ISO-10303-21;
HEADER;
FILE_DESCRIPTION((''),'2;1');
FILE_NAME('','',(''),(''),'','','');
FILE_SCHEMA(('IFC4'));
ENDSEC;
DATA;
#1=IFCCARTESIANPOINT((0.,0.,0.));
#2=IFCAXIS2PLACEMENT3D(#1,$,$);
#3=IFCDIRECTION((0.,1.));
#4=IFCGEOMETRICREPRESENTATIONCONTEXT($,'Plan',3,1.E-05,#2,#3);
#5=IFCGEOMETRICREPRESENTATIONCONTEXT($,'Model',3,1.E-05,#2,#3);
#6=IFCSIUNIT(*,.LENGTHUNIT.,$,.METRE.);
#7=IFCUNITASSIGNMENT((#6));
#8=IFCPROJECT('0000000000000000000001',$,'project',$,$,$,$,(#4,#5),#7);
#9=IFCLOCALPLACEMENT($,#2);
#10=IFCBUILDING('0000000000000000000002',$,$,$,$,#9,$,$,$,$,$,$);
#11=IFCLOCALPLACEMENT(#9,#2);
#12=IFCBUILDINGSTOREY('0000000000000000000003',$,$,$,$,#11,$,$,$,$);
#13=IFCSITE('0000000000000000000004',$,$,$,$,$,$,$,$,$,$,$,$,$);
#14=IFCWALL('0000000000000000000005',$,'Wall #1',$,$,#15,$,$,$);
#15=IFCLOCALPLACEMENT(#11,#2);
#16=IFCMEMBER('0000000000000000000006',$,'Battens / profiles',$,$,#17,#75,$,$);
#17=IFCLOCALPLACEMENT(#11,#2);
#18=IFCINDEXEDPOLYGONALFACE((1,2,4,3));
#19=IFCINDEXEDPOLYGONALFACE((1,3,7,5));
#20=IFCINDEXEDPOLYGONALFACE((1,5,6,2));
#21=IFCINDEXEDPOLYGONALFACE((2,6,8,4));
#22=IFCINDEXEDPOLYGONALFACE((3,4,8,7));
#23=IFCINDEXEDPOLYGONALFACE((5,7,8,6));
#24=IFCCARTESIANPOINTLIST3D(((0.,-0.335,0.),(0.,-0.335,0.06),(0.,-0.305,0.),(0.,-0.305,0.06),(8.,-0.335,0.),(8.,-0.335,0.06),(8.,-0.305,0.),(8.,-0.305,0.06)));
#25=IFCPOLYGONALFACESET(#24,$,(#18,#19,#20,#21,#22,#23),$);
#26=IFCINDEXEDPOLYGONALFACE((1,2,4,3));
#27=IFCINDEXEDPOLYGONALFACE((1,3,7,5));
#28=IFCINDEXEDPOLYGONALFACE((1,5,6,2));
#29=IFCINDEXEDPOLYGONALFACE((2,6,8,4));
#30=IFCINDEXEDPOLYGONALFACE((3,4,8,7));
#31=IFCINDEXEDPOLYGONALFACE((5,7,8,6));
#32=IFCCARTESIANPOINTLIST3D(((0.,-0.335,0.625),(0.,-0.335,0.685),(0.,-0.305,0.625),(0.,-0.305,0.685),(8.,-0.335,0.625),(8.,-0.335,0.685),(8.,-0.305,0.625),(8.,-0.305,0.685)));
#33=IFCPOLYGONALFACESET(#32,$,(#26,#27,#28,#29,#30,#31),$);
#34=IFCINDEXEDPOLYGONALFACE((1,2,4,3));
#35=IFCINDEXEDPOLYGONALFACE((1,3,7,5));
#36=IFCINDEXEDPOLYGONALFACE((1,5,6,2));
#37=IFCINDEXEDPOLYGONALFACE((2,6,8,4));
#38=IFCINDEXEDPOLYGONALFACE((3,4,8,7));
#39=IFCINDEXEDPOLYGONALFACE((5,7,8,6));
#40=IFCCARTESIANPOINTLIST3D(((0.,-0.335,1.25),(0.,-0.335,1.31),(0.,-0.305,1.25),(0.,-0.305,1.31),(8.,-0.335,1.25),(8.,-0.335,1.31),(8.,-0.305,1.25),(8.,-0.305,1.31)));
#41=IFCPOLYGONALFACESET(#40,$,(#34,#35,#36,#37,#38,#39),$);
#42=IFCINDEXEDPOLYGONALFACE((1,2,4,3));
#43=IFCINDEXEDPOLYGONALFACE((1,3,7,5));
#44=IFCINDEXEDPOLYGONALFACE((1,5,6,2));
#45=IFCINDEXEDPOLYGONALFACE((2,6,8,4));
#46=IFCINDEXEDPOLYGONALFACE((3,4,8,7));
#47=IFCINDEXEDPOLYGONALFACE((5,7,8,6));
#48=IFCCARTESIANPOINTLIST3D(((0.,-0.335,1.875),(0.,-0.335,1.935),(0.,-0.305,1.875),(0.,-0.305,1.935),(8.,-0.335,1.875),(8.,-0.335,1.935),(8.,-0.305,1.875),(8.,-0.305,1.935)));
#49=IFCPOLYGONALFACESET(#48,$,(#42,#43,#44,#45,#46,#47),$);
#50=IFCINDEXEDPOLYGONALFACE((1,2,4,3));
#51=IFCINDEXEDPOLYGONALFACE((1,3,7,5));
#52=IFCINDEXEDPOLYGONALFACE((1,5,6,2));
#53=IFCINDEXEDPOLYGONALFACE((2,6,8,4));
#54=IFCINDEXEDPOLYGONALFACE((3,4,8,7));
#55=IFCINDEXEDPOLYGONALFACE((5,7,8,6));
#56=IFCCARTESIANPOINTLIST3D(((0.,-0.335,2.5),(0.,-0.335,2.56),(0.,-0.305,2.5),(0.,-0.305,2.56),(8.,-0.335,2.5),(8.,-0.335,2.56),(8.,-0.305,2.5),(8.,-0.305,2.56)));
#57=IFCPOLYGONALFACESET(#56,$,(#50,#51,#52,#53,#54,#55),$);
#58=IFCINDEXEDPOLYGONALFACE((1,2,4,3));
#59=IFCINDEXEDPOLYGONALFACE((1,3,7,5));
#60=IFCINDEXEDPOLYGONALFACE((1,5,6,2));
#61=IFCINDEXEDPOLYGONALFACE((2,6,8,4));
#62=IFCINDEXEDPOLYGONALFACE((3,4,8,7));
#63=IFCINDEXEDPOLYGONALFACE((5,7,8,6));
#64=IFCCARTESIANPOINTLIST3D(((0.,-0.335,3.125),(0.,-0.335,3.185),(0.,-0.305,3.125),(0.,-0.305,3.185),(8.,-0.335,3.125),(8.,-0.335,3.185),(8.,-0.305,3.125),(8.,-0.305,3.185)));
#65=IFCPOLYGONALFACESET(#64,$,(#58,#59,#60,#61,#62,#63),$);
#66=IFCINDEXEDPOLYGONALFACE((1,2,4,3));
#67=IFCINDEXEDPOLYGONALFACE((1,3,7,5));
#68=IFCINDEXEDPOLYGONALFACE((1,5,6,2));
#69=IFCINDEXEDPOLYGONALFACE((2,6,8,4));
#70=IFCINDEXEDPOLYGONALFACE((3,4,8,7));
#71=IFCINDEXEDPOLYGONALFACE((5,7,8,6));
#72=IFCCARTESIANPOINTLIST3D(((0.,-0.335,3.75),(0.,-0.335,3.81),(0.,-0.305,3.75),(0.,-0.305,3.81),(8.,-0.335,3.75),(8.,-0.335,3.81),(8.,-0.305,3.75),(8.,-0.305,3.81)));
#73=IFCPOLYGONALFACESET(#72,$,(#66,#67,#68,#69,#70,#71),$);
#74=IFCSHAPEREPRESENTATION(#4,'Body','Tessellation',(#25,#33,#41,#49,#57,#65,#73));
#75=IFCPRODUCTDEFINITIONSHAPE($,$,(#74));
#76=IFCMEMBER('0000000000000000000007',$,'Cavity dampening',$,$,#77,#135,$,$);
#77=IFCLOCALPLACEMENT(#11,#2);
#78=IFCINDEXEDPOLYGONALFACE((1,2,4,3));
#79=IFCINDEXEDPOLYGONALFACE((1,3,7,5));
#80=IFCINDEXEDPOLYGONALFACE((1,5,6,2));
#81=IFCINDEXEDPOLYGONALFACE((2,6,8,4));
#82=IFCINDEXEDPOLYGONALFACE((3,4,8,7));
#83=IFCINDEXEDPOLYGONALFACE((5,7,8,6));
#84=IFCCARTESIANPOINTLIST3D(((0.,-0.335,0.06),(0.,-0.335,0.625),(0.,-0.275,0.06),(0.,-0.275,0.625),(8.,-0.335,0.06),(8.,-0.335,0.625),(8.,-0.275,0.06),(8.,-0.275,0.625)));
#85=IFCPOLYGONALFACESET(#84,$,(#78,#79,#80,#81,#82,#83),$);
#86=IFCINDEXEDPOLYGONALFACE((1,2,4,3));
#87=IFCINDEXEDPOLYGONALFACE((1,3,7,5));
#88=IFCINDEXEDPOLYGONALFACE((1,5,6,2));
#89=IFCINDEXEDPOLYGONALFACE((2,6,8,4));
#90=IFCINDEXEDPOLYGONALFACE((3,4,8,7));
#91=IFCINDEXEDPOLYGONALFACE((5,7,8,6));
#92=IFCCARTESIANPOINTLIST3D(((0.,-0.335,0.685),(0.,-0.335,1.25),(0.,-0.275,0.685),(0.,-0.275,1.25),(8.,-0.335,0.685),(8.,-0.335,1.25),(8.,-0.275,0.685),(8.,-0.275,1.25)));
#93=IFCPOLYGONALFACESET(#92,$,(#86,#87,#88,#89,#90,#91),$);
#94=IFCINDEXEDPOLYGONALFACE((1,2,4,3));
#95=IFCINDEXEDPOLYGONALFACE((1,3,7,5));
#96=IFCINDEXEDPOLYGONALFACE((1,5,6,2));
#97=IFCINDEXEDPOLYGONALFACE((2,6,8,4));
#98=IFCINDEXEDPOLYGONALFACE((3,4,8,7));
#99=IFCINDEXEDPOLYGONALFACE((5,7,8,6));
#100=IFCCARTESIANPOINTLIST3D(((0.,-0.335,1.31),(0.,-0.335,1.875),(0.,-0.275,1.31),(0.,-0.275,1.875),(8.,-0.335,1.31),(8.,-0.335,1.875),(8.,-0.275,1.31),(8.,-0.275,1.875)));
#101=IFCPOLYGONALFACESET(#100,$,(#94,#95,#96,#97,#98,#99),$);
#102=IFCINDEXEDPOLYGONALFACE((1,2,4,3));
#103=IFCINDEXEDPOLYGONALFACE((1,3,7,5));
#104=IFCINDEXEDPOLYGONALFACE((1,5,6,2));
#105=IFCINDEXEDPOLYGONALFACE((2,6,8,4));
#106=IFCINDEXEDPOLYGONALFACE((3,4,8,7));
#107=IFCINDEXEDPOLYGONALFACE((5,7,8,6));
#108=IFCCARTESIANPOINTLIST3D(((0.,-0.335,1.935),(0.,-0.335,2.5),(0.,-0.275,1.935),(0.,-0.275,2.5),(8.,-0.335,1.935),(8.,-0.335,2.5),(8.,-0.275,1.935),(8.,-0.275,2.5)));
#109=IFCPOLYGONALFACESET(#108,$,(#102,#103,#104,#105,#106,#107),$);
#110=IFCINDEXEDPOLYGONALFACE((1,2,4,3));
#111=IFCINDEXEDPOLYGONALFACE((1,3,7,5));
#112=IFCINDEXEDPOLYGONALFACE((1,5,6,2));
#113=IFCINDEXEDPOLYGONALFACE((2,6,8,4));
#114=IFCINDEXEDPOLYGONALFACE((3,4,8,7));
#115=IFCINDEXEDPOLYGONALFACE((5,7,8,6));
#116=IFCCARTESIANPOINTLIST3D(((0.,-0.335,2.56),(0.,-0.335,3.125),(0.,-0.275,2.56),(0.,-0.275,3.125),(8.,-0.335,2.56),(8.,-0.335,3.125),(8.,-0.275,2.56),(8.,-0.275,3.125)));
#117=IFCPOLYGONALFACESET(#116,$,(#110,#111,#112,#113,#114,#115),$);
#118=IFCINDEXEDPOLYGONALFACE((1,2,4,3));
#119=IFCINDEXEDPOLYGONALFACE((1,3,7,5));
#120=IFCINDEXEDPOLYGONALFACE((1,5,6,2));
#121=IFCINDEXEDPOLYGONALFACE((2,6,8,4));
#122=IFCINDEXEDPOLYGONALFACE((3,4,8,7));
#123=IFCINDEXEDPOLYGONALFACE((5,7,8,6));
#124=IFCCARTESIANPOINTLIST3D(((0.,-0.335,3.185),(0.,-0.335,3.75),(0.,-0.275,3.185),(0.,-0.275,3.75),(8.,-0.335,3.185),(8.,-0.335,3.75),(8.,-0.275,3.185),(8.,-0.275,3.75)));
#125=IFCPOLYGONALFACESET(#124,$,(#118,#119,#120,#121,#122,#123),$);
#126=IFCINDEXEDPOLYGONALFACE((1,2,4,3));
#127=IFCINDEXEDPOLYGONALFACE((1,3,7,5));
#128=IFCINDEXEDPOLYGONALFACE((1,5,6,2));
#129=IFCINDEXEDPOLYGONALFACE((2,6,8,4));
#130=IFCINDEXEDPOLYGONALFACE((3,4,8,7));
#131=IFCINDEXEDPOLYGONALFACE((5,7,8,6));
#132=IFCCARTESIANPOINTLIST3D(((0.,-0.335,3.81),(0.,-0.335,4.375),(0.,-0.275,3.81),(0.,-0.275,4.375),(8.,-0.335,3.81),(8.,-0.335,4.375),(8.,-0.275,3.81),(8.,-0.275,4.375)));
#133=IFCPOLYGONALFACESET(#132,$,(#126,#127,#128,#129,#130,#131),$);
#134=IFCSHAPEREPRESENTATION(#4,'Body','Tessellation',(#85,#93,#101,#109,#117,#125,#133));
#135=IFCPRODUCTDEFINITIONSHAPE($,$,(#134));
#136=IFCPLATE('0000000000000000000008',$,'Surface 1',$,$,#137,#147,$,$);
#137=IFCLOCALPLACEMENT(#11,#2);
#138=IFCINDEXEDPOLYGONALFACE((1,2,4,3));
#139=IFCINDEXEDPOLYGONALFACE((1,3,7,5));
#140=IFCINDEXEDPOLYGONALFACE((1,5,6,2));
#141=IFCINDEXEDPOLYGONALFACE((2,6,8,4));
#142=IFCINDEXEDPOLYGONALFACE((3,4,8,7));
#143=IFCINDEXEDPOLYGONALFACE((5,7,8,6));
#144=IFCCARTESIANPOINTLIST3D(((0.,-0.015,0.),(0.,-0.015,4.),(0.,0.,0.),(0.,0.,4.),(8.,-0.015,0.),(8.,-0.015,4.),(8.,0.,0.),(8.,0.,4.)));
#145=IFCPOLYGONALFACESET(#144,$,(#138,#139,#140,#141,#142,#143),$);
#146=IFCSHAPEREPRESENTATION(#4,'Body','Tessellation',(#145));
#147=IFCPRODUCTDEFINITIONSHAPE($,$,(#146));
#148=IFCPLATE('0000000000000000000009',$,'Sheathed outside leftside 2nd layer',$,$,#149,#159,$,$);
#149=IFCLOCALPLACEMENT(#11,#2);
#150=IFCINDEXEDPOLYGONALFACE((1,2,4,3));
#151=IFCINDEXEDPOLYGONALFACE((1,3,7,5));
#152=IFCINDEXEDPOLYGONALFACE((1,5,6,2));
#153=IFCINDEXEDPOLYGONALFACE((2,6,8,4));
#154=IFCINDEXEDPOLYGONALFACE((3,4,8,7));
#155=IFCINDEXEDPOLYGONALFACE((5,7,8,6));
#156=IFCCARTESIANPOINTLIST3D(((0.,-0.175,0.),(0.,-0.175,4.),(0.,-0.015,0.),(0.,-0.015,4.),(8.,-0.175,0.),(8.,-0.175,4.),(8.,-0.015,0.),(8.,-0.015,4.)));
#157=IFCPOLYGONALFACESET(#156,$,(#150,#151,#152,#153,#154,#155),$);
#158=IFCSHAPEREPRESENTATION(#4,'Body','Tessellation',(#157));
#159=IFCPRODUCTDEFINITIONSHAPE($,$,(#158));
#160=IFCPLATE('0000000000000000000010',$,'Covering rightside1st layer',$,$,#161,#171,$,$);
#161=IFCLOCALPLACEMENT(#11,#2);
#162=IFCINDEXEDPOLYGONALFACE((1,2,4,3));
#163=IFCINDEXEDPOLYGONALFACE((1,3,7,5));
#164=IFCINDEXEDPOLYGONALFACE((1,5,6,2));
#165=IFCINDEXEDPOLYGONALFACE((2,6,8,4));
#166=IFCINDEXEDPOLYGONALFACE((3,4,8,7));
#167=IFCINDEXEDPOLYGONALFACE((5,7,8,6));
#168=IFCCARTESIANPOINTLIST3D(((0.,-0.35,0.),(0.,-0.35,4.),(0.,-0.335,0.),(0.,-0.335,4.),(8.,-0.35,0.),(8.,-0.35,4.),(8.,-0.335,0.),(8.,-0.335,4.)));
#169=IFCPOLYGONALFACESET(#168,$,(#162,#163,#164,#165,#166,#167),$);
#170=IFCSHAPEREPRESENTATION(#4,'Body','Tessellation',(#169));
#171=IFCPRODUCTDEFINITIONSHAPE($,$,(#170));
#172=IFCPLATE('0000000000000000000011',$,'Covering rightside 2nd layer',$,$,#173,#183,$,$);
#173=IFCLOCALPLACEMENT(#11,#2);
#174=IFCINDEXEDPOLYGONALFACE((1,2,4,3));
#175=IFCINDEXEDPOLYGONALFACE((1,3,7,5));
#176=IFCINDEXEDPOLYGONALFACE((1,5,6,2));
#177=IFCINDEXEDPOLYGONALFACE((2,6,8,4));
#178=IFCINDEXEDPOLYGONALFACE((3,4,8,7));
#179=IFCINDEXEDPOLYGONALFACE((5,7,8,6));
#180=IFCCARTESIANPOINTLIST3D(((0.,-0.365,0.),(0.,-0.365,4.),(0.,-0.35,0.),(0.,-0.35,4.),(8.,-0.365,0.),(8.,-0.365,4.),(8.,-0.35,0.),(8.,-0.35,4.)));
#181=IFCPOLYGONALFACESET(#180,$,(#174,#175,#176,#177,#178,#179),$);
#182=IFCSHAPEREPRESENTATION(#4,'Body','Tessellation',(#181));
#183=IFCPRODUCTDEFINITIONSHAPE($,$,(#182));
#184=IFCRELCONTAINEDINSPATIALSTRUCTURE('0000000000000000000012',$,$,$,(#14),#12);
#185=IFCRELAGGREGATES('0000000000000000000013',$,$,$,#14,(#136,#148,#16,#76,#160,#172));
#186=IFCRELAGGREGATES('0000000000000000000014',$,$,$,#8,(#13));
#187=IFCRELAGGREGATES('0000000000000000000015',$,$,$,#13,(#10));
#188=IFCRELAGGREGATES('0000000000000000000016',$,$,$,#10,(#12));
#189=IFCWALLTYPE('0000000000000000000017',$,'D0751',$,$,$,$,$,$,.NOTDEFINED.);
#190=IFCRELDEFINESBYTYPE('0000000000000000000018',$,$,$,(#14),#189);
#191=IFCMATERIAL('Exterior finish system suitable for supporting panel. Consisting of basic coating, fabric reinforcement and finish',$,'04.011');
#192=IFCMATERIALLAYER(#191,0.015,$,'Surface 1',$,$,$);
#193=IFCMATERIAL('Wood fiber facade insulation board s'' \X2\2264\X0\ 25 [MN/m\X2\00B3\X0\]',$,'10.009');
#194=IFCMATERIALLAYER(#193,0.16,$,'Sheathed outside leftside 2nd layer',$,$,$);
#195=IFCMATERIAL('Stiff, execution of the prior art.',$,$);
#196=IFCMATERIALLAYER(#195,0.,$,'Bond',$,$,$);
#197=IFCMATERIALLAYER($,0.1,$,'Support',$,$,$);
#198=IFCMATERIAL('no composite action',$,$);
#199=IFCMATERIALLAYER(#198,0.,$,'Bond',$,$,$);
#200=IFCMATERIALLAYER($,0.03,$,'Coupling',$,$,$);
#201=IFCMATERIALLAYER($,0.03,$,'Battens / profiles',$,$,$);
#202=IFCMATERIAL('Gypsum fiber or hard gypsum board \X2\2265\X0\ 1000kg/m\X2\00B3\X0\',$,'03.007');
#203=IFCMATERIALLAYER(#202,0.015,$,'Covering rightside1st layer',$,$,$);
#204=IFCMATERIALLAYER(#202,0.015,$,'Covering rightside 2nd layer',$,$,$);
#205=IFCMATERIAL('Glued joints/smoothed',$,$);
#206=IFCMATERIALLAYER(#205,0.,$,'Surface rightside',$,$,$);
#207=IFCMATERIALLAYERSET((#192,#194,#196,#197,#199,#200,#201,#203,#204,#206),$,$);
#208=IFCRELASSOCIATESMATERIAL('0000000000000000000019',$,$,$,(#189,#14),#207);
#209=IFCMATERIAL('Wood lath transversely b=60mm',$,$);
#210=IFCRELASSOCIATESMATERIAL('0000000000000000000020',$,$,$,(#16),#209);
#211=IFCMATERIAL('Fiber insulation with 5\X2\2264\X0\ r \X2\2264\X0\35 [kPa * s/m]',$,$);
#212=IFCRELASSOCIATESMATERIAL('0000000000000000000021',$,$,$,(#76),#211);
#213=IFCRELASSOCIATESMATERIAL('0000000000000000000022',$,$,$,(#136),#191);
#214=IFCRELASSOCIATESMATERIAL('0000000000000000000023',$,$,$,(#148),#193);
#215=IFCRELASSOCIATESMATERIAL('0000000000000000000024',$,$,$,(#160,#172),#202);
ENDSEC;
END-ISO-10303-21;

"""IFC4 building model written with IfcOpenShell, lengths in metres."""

from ifc_helpers import new_model, si_unit, direction, frame, frame_2d, origin, origin_with_axes, place, context, project, spatial, rectangle, extrude, material, layer, layer_set, type_object, element, aggregate, save


model = new_model("IFC4")

# Units and contexts
plan_context = context("Plan", 3, precision=1e-05, world=origin(), true_north=direction((0.0, 1.0)))
model_context = context("Model", 3, precision=1e-05, world=origin(), true_north=direction((0.0, 1.0)))
ifc_project = project(units=[si_unit("LENGTHUNIT", "METRE")], contexts=[plan_context, model_context])

# Site, building, storey
site = spatial("IfcSite", under=ifc_project)
building_placement = place(None, origin())
building = spatial("IfcBuilding", under=site, at=building_placement)
storey_placement = place(building_placement, origin())
storey = spatial("IfcBuildingStorey", under=building, at=storey_placement)

# Wall, members, plates
ifc_material_1 = material(Name="Exterior finish system suitable for supporting panel. Consisting of basic coating, fabric reinforcement and finish", Category="04.011")
ifc_layer_1 = layer(ifc_material_1, 0.015, Name="Surface 1")
ifc_material_2 = material(Name="Wood fiber facade insulation board s' ≤ 25 [MN/m³]", Category="10.009")
ifc_layer_2 = layer(ifc_material_2, 0.16, Name="Sheathed outside leftside 2nd layer")
ifc_material_3 = material(Name="Stiff, execution of the prior art.")
ifc_layer_3 = layer(ifc_material_3, 0.0, Name="Bond")
ifc_layer_4 = layer(None, 0.1, Name="Support")
ifc_material_4 = material(Name="no composite action")
ifc_layer_5 = layer(ifc_material_4, 0.0, Name="Bond")
ifc_layer_6 = layer(None, 0.03, Name="Coupling")
ifc_layer_7 = layer(None, 0.03, Name="Battens / profiles")
ifc_material_5 = material(Name="Gypsum fiber or hard gypsum board ≥ 1000kg/m³", Category="03.007")
ifc_layer_8 = layer(ifc_material_5, 0.015, Name="Covering rightside1st layer")
ifc_layer_9 = layer(ifc_material_5, 0.015, Name="Covering rightside 2nd layer")
ifc_material_6 = material(Name="Glued joints/smoothed")
ifc_layer_10 = layer(ifc_material_6, 0.0, Name="Surface rightside")
ifc_layer_set = layer_set([ifc_layer_1, ifc_layer_2, ifc_layer_3, ifc_layer_4, ifc_layer_5, ifc_layer_6, ifc_layer_7, ifc_layer_8, ifc_layer_9, ifc_layer_10])
wall_type = type_object("IfcWallType", Name="D0751", PredefinedType="NOTDEFINED", material=ifc_layer_set)
wall_placement = place(None, frame((0.0, 0.0, 0.0), z_axis=(0.0, -1.0, 0.0), x_axis=(1.0, 0.0, 0.0)))
wall = element("IfcWall", 1, at=wall_placement, inside=storey, type_object=wall_type, material=ifc_layer_set, Name="Wall #1")
ifc_material_7 = material(Name="Wood lath transversely b=60mm")
member_1_placement = place(wall_placement, origin())
member_1 = element("IfcMember", 2, at=member_1_placement, material=ifc_material_7, Name="Battens / profiles", context=plan_context, shape_type="SweptSolid", body=[
    extrude(rectangle(XDim=0.06, YDim=0.03, at=frame_2d((0.03, 0.015), x_axis=(1.0, 0.0))), frame((0.0, 0.0, 0.305), z_axis=(1.0, 0.0, 0.0), x_axis=(0.0, 1.0, 0.0)), (0.0, 0.0, 1.0), 8.0),
    extrude(rectangle(XDim=0.06, YDim=0.03, at=frame_2d((0.03, 0.015), x_axis=(1.0, 0.0))), frame((0.0, 0.625, 0.305), z_axis=(1.0, 0.0, 0.0), x_axis=(0.0, 1.0, 0.0)), (0.0, 0.0, 1.0), 8.0),
    extrude(rectangle(XDim=0.06, YDim=0.03, at=frame_2d((0.03, 0.015), x_axis=(1.0, 0.0))), frame((0.0, 1.25, 0.305), z_axis=(1.0, 0.0, 0.0), x_axis=(0.0, 1.0, 0.0)), (0.0, 0.0, 1.0), 8.0),
    extrude(rectangle(XDim=0.06, YDim=0.03, at=frame_2d((0.03, 0.015), x_axis=(1.0, 0.0))), frame((0.0, 1.875, 0.305), z_axis=(1.0, 0.0, 0.0), x_axis=(0.0, 1.0, 0.0)), (0.0, 0.0, 1.0), 8.0),
    extrude(rectangle(XDim=0.06, YDim=0.03, at=frame_2d((0.03, 0.015), x_axis=(1.0, 0.0))), frame((0.0, 2.5, 0.305), z_axis=(1.0, 0.0, 0.0), x_axis=(0.0, 1.0, 0.0)), (0.0, 0.0, 1.0), 8.0),
    extrude(rectangle(XDim=0.06, YDim=0.03, at=frame_2d((0.03, 0.015), x_axis=(1.0, 0.0))), frame((0.0, 3.125, 0.305), z_axis=(1.0, 0.0, 0.0), x_axis=(0.0, 1.0, 0.0)), (0.0, 0.0, 1.0), 8.0),
    extrude(rectangle(XDim=0.06, YDim=0.03, at=frame_2d((0.03, 0.015), x_axis=(1.0, 0.0))), frame((0.0, 3.75, 0.305), z_axis=(1.0, 0.0, 0.0), x_axis=(0.0, 1.0, 0.0)), (0.0, 0.0, 1.0), 8.0),
])
ifc_material_8 = material(Name="Fiber insulation with 5≤ r ≤35 [kPa * s/m]")
member_2_placement = place(wall_placement, origin())
member_2 = element("IfcMember", 3, at=member_2_placement, material=ifc_material_8, Name="Cavity dampening", context=plan_context, shape_type="SweptSolid", body=[
    extrude(rectangle(XDim=0.565, YDim=0.06, at=frame_2d((0.2825, 0.03), x_axis=(1.0, 0.0))), frame((0.0, 0.06, 0.275), z_axis=(1.0, 0.0, 0.0), x_axis=(0.0, 1.0, 0.0)), (0.0, 0.0, 1.0), 8.0),
    extrude(rectangle(XDim=0.565, YDim=0.06, at=frame_2d((0.2825, 0.03), x_axis=(1.0, 0.0))), frame((0.0, 0.685, 0.275), z_axis=(1.0, 0.0, 0.0), x_axis=(0.0, 1.0, 0.0)), (0.0, 0.0, 1.0), 8.0),
    extrude(rectangle(XDim=0.565, YDim=0.06, at=frame_2d((0.2825, 0.03), x_axis=(1.0, 0.0))), frame((0.0, 1.31, 0.275), z_axis=(1.0, 0.0, 0.0), x_axis=(0.0, 1.0, 0.0)), (0.0, 0.0, 1.0), 8.0),
    extrude(rectangle(XDim=0.565, YDim=0.06, at=frame_2d((0.2825, 0.03), x_axis=(1.0, 0.0))), frame((0.0, 1.935, 0.275), z_axis=(1.0, 0.0, 0.0), x_axis=(0.0, 1.0, 0.0)), (0.0, 0.0, 1.0), 8.0),
    extrude(rectangle(XDim=0.565, YDim=0.06, at=frame_2d((0.2825, 0.03), x_axis=(1.0, 0.0))), frame((0.0, 2.56, 0.275), z_axis=(1.0, 0.0, 0.0), x_axis=(0.0, 1.0, 0.0)), (0.0, 0.0, 1.0), 8.0),
    extrude(rectangle(XDim=0.565, YDim=0.06, at=frame_2d((0.2825, 0.03), x_axis=(1.0, 0.0))), frame((0.0, 3.185, 0.275), z_axis=(1.0, 0.0, 0.0), x_axis=(0.0, 1.0, 0.0)), (0.0, 0.0, 1.0), 8.0),
    extrude(rectangle(XDim=0.565, YDim=0.06, at=frame_2d((0.2825, 0.03), x_axis=(1.0, 0.0))), frame((0.0, 3.81, 0.275), z_axis=(1.0, 0.0, 0.0), x_axis=(0.0, 1.0, 0.0)), (0.0, 0.0, 1.0), 8.0),
])
plate_1_placement = place(wall_placement, origin())
plate_1 = element("IfcPlate", 4, at=plate_1_placement, material=ifc_material_1, Name="Surface 1", context=plan_context, shape_type="SweptSolid", body=[
    extrude(rectangle(XDim=8.0, YDim=4.0, at=frame_2d((4.0, 2.0), x_axis=(1.0, 0.0))), origin_with_axes(), (0.0, 0.0, 1.0), 0.015),
])
plate_2_placement = place(wall_placement, origin())
plate_2 = element("IfcPlate", 5, at=plate_2_placement, material=ifc_material_2, Name="Sheathed outside leftside 2nd layer", context=plan_context, shape_type="SweptSolid", body=[
    extrude(rectangle(XDim=8.0, YDim=4.0, at=frame_2d((4.0, 2.0), x_axis=(1.0, 0.0))), frame((0.0, 0.0, 0.015), z_axis=(0.0, 0.0, 1.0), x_axis=(1.0, 0.0, 0.0)), (0.0, 0.0, 1.0), 0.16),
])
plate_3_placement = place(wall_placement, origin())
plate_3 = element("IfcPlate", 6, at=plate_3_placement, material=ifc_material_5, Name="Covering rightside1st layer", context=plan_context, shape_type="SweptSolid", body=[
    extrude(rectangle(XDim=8.0, YDim=4.0, at=frame_2d((4.0, 2.0), x_axis=(1.0, 0.0))), frame((0.0, 0.0, 0.335), z_axis=(0.0, 0.0, 1.0), x_axis=(1.0, 0.0, 0.0)), (0.0, 0.0, 1.0), 0.015),
])
plate_4_placement = place(wall_placement, origin())
plate_4 = element("IfcPlate", 7, at=plate_4_placement, material=ifc_material_5, Name="Covering rightside 2nd layer", context=plan_context, shape_type="SweptSolid", body=[
    extrude(rectangle(XDim=8.0, YDim=4.0, at=frame_2d((4.0, 2.0), x_axis=(1.0, 0.0))), frame((0.0, 0.0, 0.35), z_axis=(0.0, 0.0, 1.0), x_axis=(1.0, 0.0, 0.0)), (0.0, 0.0, 1.0), 0.015),
])
aggregate(wall, [plate_1, plate_2, member_1, member_2, plate_3, plate_4])

save(model, "model.ifc")
